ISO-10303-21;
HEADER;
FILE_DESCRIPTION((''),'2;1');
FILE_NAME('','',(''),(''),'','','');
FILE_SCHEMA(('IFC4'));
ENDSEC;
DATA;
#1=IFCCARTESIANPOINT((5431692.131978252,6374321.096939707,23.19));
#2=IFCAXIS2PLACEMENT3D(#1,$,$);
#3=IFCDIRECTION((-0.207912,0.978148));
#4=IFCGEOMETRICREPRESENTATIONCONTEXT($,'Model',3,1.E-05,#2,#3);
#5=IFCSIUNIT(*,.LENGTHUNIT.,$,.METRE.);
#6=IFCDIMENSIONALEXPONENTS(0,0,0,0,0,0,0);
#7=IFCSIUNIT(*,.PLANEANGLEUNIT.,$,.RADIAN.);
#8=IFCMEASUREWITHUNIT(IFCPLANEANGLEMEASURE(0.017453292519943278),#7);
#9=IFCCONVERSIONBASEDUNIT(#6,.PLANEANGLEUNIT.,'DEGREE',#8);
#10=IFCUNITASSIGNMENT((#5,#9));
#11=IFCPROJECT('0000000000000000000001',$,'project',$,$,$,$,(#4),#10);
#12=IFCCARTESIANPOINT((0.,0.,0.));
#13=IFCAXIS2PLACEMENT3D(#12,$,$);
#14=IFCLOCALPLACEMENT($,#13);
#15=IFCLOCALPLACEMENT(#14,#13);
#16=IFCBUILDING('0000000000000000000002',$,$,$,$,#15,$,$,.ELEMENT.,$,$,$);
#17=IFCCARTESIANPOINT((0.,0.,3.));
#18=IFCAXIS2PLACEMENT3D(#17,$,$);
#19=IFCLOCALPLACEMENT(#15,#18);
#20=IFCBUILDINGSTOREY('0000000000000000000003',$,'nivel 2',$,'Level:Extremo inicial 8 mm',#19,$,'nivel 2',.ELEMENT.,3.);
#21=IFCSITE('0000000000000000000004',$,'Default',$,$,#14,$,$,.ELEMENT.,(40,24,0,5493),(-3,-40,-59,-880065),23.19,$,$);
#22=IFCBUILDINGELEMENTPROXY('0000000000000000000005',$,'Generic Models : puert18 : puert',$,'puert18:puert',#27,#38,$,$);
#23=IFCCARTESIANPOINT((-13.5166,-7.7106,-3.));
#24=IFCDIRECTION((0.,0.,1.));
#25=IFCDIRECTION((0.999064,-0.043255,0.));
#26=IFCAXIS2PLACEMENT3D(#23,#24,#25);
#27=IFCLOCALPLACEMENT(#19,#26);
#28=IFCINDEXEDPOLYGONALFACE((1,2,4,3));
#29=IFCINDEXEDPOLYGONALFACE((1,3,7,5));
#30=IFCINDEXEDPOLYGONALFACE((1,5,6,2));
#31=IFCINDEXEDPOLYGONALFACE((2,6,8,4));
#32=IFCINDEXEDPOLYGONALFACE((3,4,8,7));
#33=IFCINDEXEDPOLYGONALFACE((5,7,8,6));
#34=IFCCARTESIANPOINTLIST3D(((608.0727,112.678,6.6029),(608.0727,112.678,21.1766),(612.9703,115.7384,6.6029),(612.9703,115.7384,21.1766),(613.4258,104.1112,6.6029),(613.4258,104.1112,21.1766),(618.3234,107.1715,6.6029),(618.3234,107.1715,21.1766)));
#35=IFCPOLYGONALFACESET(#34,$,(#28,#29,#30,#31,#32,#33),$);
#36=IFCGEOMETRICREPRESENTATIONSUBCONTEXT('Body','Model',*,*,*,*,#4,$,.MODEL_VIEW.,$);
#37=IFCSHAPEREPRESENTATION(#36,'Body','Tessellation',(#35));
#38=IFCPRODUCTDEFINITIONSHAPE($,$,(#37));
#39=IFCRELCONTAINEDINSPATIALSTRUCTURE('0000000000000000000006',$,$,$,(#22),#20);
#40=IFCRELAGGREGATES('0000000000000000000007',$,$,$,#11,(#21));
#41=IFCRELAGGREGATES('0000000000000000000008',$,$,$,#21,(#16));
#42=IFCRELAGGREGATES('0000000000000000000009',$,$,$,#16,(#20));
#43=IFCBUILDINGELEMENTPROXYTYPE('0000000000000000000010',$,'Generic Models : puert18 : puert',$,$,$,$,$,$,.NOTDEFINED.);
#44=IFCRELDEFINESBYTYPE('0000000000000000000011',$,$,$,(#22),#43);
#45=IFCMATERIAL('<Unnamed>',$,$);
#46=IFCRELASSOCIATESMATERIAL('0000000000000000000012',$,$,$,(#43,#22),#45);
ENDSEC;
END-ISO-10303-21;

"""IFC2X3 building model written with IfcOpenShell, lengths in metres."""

from ifc_helpers import new_model, entity, si_unit, converted_unit, direction, frame, frame_2d, origin, place, context, subcontext, project, spatial, rectangle, extrude, source, transform, mapped, material, type_object, type_shapes, element, save


model = new_model("IFC2X3")

# Units and contexts
model_context = context("Model", 3, precision=1e-05, world=frame((5431692.131978252, 6374321.096939707, 23.19)), true_north=direction((-0.207912, 0.978148)))
body_context = subcontext(model_context, "Body", "Model", "MODEL_VIEW")
ifc_project = project(units=[si_unit("LENGTHUNIT", "METRE"), converted_unit("PLANEANGLEUNIT", "DEGREE", entity("IfcPlaneAngleMeasure", 0.017453292519943278), si_unit("PLANEANGLEUNIT", "RADIAN"), dimensions=[0, 0, 0, 0, 0, 0, 0])], contexts=[model_context])

# Site, building, storey
site_placement = place(None, origin())
site = spatial("IfcSite", under=ifc_project, at=site_placement, Name="Default", CompositionType="ELEMENT", RefLatitude=(40, 24, 0, 5493), RefLongitude=(-3, -40, -59, -880065), RefElevation=23.19)
building_placement = place(site_placement, origin())
building = spatial("IfcBuilding", under=site, at=building_placement, CompositionType="ELEMENT")
storey_placement = place(building_placement, frame((0.0, 0.0, 3.0)))
storey = spatial("IfcBuildingStorey", under=building, at=storey_placement, Name="nivel 2", ObjectType="Level:Extremo inicial 8 mm", LongName="nivel 2", CompositionType="ELEMENT", Elevation=3.0)

# Building element proxy
ifc_material_1 = material(Name="<Unnamed>")
building_element_proxy_type = type_object("IfcBuildingElementProxyType", Name="Generic Models : puert18 : puert", PredefinedType="NOTDEFINED", material=ifc_material_1)
shared_shape = source(origin(), body_context, "Body", "SweptSolid", [
    extrude(rectangle(XDim=5.7752, YDim=10.1018, at=frame_2d((0.0, 0.0), x_axis=(1.0, 0.0))), frame((613.198, 109.9248, 6.6029), z_axis=(0.0, 0.0, 1.0), x_axis=(-0.848048, -0.529919, 0.0)), (0.0, 0.0, 1.0), 14.5737),
])
type_shapes(building_element_proxy_type, [shared_shape])
proxy_placement = place(storey_placement, frame((-13.5166, -7.7106, -3.0), z_axis=(0.0, 0.0, 1.0), x_axis=(0.999064, -0.043255, 0.0)))
element("IfcBuildingElementProxy", 1, at=proxy_placement, inside=storey, type_object=building_element_proxy_type, material=ifc_material_1, Name="Generic Models : puert18 : puert", ObjectType="puert18:puert", context=body_context, shape_type="MappedRepresentation", body=[
    mapped(shared_shape, transform((0.0, 0.0, 0.0), scale=1.0)),
])

save(model, "model.ifc")
